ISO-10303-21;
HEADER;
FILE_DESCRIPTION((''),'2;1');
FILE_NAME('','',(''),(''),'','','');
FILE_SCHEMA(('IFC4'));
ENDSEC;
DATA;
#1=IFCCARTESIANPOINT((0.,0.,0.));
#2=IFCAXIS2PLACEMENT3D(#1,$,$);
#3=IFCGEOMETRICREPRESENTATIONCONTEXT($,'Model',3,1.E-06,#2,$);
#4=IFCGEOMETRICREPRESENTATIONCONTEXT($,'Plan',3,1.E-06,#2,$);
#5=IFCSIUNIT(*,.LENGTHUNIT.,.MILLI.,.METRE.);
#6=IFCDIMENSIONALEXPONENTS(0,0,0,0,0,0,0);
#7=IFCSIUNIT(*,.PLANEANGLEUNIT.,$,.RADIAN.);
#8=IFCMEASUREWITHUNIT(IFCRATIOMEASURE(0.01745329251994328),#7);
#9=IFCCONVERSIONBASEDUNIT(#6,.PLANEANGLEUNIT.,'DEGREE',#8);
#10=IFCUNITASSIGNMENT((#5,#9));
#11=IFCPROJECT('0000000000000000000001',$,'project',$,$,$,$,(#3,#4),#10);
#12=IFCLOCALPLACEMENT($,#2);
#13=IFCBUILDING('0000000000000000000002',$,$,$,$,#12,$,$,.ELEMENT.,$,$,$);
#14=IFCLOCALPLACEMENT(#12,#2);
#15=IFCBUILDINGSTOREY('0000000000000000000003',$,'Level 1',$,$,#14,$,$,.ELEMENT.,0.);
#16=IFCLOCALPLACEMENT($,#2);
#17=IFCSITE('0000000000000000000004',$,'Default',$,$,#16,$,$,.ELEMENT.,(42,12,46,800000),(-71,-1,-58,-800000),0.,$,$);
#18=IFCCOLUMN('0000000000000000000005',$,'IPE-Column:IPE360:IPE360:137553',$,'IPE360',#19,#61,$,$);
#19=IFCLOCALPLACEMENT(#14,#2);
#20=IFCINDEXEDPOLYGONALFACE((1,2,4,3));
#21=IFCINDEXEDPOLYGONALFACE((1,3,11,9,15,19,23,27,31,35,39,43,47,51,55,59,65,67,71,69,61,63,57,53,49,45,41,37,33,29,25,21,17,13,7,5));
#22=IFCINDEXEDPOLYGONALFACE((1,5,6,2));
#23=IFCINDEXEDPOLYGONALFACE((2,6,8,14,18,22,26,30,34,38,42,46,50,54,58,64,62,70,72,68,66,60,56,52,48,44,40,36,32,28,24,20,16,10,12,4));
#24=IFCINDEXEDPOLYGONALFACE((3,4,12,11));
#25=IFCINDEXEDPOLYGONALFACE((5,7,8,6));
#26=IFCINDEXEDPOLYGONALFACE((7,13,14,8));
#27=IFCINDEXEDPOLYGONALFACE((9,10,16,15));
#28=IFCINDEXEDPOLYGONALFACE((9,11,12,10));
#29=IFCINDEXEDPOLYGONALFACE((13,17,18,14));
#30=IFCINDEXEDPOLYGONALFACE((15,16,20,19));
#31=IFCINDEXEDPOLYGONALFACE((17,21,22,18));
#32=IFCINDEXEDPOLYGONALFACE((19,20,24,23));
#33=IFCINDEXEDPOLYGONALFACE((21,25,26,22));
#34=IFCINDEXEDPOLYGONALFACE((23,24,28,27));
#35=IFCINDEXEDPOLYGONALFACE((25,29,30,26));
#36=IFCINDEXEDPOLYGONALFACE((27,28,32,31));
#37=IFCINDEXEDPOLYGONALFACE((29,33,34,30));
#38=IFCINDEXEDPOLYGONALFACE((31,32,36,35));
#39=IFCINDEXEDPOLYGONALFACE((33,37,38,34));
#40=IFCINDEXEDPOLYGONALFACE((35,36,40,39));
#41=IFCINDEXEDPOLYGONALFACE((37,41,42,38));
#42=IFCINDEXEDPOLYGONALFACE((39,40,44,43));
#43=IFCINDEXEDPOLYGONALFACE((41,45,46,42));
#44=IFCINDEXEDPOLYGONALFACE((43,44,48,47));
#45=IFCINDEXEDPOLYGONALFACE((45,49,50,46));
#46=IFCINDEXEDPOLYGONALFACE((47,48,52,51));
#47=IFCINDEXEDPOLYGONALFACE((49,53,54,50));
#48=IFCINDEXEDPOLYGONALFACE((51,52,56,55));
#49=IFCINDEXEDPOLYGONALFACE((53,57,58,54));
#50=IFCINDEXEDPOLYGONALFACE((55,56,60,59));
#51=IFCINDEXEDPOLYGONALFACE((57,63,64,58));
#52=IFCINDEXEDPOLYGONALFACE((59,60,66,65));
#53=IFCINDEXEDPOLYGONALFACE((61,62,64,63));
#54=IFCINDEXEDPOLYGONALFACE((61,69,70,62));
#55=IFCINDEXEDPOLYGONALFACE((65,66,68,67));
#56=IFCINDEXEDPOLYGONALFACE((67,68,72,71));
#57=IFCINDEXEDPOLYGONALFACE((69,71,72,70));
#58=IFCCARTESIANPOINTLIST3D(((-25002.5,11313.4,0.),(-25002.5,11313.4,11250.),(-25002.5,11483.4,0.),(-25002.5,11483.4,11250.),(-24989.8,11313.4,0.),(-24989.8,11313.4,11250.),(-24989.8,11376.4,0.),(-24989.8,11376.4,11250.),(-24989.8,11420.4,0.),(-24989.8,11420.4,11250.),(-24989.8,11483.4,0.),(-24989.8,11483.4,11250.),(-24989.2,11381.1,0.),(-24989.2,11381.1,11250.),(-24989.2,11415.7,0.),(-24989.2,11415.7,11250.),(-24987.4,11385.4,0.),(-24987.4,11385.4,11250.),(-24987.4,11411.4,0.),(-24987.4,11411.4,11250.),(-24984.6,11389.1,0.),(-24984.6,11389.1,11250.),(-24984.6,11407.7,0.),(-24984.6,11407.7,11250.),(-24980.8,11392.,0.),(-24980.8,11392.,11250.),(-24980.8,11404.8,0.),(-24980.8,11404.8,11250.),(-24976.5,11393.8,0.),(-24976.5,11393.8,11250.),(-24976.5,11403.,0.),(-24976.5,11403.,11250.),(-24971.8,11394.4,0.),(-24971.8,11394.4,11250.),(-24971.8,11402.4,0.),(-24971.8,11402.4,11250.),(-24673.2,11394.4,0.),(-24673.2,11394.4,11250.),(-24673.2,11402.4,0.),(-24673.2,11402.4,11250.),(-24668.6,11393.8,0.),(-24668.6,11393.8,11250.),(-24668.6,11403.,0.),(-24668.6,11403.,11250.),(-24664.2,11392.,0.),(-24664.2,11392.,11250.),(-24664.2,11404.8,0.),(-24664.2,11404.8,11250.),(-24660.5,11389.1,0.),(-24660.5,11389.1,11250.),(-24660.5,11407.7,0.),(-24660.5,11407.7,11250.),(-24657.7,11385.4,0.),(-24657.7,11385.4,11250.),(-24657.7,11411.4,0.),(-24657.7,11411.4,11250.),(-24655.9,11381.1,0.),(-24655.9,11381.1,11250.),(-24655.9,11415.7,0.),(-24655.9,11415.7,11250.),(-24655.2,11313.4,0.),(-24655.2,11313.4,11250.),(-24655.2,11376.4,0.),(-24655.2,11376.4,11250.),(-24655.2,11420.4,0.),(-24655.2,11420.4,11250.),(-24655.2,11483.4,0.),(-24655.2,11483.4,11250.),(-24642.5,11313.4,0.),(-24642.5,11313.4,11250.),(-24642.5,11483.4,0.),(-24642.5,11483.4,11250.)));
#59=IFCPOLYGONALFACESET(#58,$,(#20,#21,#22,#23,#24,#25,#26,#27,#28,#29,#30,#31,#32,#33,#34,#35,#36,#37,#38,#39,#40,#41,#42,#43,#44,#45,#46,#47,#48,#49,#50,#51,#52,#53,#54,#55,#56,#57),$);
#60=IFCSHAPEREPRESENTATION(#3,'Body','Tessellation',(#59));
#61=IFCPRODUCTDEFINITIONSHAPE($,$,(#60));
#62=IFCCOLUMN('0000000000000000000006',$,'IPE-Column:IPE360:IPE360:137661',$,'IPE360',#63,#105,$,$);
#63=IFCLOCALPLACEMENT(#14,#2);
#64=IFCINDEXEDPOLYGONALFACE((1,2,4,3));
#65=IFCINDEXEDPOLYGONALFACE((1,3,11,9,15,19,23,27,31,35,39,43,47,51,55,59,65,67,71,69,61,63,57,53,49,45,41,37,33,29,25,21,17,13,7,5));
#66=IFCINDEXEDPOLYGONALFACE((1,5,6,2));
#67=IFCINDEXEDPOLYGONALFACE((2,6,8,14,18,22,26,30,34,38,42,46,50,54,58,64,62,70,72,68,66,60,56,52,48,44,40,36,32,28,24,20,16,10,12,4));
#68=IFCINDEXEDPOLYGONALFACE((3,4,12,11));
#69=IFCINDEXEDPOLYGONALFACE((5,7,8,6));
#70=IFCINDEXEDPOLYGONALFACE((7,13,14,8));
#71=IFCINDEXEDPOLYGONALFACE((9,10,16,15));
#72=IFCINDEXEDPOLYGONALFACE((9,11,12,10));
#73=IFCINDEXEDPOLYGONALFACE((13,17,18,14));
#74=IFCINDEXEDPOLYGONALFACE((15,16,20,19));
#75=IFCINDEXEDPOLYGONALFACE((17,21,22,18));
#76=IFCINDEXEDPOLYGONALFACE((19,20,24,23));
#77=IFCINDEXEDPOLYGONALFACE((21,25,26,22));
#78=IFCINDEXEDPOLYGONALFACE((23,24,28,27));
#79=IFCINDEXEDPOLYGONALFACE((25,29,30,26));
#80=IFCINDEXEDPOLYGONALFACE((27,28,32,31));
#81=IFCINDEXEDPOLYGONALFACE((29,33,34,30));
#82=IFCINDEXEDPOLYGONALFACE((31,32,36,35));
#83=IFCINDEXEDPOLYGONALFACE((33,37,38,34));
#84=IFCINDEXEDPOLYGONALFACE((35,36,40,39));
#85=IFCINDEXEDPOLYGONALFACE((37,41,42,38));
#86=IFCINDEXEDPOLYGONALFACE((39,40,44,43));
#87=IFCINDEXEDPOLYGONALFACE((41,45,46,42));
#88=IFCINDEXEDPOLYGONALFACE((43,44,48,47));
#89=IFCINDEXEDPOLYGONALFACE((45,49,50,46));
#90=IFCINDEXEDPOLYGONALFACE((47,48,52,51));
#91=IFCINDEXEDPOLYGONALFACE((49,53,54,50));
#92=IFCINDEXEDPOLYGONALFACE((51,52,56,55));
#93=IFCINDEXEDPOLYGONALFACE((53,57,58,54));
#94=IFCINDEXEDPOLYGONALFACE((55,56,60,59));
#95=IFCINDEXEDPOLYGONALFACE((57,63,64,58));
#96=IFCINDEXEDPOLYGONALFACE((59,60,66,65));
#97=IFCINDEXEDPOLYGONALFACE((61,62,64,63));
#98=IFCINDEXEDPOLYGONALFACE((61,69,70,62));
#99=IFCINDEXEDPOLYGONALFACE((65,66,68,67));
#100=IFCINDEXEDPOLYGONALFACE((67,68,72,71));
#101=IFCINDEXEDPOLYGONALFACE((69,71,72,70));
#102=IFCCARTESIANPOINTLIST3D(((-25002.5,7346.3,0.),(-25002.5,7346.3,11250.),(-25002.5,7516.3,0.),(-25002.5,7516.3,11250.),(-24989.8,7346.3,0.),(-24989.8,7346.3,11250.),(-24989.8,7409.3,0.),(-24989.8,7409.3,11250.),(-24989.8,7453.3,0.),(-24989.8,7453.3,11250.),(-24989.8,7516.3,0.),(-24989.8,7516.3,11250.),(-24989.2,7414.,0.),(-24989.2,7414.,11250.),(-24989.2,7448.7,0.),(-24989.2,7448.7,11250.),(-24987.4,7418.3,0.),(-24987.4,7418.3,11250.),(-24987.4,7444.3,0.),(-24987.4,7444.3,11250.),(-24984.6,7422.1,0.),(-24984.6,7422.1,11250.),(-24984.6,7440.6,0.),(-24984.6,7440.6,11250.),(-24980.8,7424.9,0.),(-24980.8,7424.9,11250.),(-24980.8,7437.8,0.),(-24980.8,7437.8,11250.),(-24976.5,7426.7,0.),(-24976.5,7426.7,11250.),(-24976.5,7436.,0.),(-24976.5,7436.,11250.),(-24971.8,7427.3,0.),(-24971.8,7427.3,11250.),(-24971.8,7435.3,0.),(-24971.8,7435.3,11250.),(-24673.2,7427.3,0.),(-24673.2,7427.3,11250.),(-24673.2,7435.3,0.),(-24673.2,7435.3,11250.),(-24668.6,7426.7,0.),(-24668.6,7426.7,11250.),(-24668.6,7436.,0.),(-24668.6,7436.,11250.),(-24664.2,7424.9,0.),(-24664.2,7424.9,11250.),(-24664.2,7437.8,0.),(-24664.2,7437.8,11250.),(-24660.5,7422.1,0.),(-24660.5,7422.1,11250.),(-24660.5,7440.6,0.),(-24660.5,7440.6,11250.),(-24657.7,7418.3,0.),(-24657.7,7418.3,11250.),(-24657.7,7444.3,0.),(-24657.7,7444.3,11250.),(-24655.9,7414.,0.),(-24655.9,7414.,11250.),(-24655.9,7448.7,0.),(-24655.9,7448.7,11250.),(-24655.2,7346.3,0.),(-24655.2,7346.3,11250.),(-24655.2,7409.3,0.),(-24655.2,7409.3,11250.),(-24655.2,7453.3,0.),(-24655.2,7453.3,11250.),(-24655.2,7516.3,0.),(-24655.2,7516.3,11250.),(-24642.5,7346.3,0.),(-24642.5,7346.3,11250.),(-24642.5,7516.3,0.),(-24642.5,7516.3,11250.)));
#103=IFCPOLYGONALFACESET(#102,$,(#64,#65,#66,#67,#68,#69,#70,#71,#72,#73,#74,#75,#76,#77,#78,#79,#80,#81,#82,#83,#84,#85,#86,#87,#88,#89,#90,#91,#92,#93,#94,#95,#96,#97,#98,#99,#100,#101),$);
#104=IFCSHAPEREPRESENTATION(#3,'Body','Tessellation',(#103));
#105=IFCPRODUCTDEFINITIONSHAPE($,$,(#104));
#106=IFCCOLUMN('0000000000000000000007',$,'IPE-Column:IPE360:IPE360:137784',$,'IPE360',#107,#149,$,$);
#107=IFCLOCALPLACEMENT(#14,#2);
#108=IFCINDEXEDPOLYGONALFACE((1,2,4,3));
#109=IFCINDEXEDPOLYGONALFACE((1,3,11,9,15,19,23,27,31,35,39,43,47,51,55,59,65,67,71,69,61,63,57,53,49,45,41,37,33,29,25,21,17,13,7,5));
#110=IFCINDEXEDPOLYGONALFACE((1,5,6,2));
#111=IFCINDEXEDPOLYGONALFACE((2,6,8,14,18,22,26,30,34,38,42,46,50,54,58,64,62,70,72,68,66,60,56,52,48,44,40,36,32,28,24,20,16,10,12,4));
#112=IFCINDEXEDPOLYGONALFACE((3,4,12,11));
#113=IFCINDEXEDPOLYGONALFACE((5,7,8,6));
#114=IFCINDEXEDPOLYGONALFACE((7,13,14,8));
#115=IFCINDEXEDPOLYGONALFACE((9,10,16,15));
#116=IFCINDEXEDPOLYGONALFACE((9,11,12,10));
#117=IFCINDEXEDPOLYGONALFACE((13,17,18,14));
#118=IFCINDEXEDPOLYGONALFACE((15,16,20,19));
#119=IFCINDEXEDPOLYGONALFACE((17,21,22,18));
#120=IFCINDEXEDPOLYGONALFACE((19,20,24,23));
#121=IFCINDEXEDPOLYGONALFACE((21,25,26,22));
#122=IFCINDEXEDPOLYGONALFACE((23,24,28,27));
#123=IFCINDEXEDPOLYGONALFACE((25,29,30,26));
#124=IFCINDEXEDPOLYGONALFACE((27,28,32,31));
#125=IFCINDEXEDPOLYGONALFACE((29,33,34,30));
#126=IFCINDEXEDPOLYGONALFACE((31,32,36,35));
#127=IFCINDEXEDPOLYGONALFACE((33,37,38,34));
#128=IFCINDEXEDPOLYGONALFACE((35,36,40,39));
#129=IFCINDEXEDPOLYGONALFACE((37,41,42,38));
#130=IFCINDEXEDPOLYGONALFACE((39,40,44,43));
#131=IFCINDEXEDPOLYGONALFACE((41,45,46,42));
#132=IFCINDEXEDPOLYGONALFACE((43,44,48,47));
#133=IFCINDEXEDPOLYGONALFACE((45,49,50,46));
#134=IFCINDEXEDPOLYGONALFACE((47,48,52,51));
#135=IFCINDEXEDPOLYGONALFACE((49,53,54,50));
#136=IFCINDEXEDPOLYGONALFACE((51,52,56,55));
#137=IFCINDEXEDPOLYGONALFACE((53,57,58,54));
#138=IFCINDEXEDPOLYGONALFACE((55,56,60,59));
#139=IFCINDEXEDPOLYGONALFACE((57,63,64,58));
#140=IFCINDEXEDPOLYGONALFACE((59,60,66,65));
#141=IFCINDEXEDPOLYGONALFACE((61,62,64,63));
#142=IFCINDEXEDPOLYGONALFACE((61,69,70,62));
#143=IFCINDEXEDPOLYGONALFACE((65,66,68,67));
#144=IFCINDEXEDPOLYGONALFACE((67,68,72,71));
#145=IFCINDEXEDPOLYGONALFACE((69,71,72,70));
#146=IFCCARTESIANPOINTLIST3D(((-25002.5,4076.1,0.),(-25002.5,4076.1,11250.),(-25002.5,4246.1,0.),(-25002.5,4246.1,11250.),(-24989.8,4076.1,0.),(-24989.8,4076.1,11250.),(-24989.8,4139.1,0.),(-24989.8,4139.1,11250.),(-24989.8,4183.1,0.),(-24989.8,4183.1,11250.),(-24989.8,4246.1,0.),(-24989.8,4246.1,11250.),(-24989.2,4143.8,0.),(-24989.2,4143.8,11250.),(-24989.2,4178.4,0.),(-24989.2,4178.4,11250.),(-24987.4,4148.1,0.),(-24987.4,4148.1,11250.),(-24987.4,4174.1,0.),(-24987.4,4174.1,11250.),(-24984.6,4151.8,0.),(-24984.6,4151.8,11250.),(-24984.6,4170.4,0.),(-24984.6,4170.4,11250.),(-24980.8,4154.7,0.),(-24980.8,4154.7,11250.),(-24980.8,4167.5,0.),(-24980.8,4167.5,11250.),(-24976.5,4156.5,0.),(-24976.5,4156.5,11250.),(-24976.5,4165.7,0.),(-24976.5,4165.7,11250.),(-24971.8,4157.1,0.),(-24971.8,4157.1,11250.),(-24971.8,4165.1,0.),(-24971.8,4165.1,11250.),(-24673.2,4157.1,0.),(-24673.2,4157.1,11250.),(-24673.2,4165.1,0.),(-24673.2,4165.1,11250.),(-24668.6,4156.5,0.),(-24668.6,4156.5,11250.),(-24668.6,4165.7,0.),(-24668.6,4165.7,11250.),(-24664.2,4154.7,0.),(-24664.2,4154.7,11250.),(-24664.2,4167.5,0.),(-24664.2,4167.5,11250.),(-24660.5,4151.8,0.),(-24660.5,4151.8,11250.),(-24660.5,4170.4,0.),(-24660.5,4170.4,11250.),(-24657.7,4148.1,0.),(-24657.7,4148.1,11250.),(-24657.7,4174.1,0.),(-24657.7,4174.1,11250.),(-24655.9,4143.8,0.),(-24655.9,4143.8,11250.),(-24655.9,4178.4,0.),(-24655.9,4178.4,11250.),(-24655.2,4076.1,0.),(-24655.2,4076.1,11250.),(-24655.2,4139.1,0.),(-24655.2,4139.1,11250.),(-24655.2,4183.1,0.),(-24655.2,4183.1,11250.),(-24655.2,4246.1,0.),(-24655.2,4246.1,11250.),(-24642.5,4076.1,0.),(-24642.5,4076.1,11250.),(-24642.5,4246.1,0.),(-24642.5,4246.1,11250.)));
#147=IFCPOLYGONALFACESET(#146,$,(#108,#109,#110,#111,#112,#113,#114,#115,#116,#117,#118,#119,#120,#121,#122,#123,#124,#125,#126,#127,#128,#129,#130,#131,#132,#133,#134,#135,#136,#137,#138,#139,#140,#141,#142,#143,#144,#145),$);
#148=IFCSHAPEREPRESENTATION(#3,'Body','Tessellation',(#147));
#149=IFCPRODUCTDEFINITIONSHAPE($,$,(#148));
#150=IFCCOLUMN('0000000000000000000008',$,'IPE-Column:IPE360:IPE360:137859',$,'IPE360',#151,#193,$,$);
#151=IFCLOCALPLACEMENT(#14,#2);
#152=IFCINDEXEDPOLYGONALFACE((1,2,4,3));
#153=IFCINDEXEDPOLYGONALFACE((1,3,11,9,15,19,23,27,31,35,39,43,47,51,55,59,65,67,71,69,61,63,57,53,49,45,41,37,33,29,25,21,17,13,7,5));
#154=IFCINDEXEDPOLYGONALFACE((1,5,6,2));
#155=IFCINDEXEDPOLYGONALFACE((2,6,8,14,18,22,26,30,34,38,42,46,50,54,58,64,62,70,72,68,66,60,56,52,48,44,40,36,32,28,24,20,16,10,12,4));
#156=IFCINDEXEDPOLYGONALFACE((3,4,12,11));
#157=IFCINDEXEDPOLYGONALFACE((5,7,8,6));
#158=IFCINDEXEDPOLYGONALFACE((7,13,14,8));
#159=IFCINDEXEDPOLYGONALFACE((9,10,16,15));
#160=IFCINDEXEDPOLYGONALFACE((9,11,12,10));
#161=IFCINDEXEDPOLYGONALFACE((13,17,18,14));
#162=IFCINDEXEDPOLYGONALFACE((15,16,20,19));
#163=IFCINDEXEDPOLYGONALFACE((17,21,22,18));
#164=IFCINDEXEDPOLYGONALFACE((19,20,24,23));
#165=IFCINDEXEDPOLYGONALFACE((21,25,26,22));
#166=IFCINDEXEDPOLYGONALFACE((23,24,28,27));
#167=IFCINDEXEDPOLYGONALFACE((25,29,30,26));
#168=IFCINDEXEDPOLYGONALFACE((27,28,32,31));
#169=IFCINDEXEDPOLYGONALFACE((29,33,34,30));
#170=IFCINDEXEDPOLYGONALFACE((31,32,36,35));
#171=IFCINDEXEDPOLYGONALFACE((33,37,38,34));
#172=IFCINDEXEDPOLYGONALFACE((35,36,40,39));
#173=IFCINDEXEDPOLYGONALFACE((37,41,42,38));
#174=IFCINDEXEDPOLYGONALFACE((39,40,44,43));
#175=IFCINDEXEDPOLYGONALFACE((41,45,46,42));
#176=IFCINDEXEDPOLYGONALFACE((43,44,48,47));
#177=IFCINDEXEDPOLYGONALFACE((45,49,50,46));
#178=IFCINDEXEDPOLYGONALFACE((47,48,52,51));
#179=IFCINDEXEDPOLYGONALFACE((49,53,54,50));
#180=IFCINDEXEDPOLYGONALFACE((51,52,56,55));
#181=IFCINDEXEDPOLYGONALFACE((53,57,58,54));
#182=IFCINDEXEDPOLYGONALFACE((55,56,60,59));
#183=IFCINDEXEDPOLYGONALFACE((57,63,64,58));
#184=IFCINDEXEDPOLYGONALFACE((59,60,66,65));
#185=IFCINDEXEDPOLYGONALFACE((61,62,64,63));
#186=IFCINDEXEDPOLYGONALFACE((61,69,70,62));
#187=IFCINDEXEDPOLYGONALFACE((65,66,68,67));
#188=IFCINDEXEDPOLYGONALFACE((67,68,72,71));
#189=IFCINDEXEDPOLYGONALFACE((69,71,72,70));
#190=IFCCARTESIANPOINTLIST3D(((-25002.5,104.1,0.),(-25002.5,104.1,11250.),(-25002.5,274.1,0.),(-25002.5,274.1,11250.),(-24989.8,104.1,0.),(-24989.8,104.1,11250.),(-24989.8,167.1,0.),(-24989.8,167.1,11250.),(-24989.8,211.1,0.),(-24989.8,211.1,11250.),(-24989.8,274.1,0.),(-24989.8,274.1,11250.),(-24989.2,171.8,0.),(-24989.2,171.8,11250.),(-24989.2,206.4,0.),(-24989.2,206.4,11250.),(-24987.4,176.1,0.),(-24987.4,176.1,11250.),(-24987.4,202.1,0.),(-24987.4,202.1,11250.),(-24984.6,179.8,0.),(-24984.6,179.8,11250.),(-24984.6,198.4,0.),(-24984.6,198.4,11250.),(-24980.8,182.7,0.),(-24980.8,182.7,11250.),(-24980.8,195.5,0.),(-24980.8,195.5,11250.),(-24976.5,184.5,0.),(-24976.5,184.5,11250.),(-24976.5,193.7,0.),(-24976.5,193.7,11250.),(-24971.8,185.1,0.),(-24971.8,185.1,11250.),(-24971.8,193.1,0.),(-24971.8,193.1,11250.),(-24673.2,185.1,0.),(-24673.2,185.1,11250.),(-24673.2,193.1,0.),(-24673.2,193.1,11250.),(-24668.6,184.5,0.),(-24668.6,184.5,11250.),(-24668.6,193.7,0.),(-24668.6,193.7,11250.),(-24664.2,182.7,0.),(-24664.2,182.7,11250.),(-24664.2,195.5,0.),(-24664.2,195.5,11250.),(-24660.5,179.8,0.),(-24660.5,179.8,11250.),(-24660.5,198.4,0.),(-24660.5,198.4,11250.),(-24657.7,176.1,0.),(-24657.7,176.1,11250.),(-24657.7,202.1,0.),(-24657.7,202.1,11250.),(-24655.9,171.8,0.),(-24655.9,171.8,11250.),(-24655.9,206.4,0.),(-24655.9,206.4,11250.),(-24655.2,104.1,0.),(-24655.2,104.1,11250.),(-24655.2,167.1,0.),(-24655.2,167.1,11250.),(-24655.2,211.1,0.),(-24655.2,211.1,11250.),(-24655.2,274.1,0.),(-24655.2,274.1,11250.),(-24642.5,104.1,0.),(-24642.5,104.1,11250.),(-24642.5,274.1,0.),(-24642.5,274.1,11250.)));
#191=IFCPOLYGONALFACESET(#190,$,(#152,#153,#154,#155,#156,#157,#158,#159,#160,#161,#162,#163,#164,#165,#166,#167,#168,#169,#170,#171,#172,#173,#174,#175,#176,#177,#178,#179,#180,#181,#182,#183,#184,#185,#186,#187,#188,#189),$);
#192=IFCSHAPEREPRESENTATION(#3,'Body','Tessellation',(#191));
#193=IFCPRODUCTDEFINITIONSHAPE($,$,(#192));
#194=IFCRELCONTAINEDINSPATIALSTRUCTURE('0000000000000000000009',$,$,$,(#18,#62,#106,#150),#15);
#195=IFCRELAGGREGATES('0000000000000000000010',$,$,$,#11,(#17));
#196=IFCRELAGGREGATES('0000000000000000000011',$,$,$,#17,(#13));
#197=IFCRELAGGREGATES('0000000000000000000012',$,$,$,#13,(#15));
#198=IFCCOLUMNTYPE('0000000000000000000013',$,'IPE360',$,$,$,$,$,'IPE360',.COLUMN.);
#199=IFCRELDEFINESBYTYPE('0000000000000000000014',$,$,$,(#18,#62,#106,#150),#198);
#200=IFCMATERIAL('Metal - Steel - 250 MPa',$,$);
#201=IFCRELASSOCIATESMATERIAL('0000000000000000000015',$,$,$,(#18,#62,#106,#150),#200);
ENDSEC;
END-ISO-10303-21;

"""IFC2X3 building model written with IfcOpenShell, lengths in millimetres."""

from ifc_helpers import new_model, entity, si_unit, converted_unit, frame, frame_2d, origin, place, context, project, spatial, polyline, circle_curve, parameter, trimmed, segment, composite_curve, outline, extrude, source, transform, mapped, material, type_object, type_shapes, element, save


model = new_model("IFC2X3")

# Units and contexts
model_context = context("Model", 3, precision=1e-06, world=origin())
plan_context = context("Plan", 3, precision=1e-06, world=origin())
ifc_project = project(units=[si_unit("LENGTHUNIT", "METRE", prefix="MILLI"), converted_unit("PLANEANGLEUNIT", "DEGREE", entity("IfcRatioMeasure", 0.01745329251994328), si_unit("PLANEANGLEUNIT", "RADIAN"), dimensions=[0, 0, 0, 0, 0, 0, 0])], contexts=[model_context, plan_context])

# Site, building, storey
site_placement = place(None, origin())
site = spatial("IfcSite", under=ifc_project, at=site_placement, Name="Default", CompositionType="ELEMENT", RefLatitude=(42, 12, 46, 800000), RefLongitude=(-71, -1, -58, -800000), RefElevation=0.0)
building_placement = place(None, origin())
building = spatial("IfcBuilding", under=site, at=building_placement, CompositionType="ELEMENT")
storey_placement = place(building_placement, origin())
storey = spatial("IfcBuildingStorey", under=building, at=storey_placement, Name="Level 1", CompositionType="ELEMENT", Elevation=0.0)

# Columns
ifc_material_1 = material(Name="Metal - Steel - 250 MPa")
column_type_1 = type_object("IfcColumnType", Name="IPE360", ElementType="IPE360", PredefinedType="COLUMN")
shared_shape_1 = source(origin(), model_context, "Body", "SweptSolid", [
    extrude(outline(composite_curve([segment(polyline([(-85.0, -180.0), (85.0, -180.0)]), True, "CONTINUOUS"), segment(polyline([(85.0, -180.0), (85.0, -167.3)]), True, "CONTINUOUS"), segment(polyline([(85.0, -167.3), (22.0, -167.3)]), True, "CONTINUOUS"), segment(trimmed(circle_curve(frame_2d((22.0, -149.3), x_axis=(-1.0, 0.0)), 18.0), [parameter(0.0)], [parameter(90.0)], True, "PARAMETER"), False, "CONTINUOUS"), segment(polyline([(4.0, -149.3), (4.0, 149.3)]), True, "CONTINUOUS"), segment(trimmed(circle_curve(frame_2d((22.0, 149.3), x_axis=(-1.0, 0.0)), 18.0), [parameter(270.0)], [parameter(0.0)], True, "PARAMETER"), False, "CONTINUOUS"), segment(polyline([(22.0, 167.3), (85.0, 167.3)]), True, "CONTINUOUS"), segment(polyline([(85.0, 167.3), (85.0, 180.0)]), True, "CONTINUOUS"), segment(polyline([(85.0, 180.0), (-85.0, 180.0)]), True, "CONTINUOUS"), segment(polyline([(-85.0, 180.0), (-85.0, 167.3)]), True, "CONTINUOUS"), segment(polyline([(-85.0, 167.3), (-22.0, 167.3)]), True, "CONTINUOUS"), segment(trimmed(circle_curve(frame_2d((-22.0, 149.3), x_axis=(-1.0, 0.0)), 18.0), [parameter(180.0)], [parameter(270.0)], True, "PARAMETER"), False, "CONTINUOUS"), segment(polyline([(-4.0, 149.3), (-4.0, -149.3)]), True, "CONTINUOUS"), segment(trimmed(circle_curve(frame_2d((-22.0, -149.3), x_axis=(-1.0, 0.0)), 18.0), [parameter(90.0)], [parameter(180.0)], True, "PARAMETER"), False, "CONTINUOUS"), segment(polyline([(-22.0, -167.3), (-85.0, -167.3)]), True, "CONTINUOUS"), segment(polyline([(-85.0, -167.3), (-85.0, -180.0)]), True, "CONTINUOUS")], self_intersect=False)), frame((0.0, 0.0, 0.0), z_axis=(0.0, 0.0, 1.0), x_axis=(-1.0, 0.0, 0.0)), (0.0, 0.0, 1.0), 11250.0),
])
type_shapes(column_type_1, [shared_shape_1])
for number, where, z_axis, x_axis, name in (
    (1, (-24822.5, 11398.4, 0.0), (0.0, 0.0, 1.0), (0.0, 1.0, 0.0), "IPE-Column:IPE360:IPE360:137553"),
    (2, (-24822.5, 7431.3, 0.0), (0.0, 0.0, 1.0), (0.0, 1.0, 0.0), "IPE-Column:IPE360:IPE360:137661"),
    (3, (-24822.5, 4161.1, 0.0), (0.0, 0.0, 1.0), (0.0, 1.0, 0.0), "IPE-Column:IPE360:IPE360:137784"),
    (4, (-24822.5, 189.1, 0.0), (0.0, 0.0, 1.0), (0.0, 1.0, 0.0), "IPE-Column:IPE360:IPE360:137859"),
):
    element("IfcColumn", number, at=place(storey_placement, frame(where, z_axis=z_axis, x_axis=x_axis)), inside=storey, type_object=column_type_1, material=ifc_material_1, Name=name, ObjectType="IPE360", context=model_context, shape_type="MappedRepresentation", body=[
        mapped(shared_shape_1, transform((0.0, 0.0, 0.0), scale=1.0)),
    ])

save(model, "model.ifc")
